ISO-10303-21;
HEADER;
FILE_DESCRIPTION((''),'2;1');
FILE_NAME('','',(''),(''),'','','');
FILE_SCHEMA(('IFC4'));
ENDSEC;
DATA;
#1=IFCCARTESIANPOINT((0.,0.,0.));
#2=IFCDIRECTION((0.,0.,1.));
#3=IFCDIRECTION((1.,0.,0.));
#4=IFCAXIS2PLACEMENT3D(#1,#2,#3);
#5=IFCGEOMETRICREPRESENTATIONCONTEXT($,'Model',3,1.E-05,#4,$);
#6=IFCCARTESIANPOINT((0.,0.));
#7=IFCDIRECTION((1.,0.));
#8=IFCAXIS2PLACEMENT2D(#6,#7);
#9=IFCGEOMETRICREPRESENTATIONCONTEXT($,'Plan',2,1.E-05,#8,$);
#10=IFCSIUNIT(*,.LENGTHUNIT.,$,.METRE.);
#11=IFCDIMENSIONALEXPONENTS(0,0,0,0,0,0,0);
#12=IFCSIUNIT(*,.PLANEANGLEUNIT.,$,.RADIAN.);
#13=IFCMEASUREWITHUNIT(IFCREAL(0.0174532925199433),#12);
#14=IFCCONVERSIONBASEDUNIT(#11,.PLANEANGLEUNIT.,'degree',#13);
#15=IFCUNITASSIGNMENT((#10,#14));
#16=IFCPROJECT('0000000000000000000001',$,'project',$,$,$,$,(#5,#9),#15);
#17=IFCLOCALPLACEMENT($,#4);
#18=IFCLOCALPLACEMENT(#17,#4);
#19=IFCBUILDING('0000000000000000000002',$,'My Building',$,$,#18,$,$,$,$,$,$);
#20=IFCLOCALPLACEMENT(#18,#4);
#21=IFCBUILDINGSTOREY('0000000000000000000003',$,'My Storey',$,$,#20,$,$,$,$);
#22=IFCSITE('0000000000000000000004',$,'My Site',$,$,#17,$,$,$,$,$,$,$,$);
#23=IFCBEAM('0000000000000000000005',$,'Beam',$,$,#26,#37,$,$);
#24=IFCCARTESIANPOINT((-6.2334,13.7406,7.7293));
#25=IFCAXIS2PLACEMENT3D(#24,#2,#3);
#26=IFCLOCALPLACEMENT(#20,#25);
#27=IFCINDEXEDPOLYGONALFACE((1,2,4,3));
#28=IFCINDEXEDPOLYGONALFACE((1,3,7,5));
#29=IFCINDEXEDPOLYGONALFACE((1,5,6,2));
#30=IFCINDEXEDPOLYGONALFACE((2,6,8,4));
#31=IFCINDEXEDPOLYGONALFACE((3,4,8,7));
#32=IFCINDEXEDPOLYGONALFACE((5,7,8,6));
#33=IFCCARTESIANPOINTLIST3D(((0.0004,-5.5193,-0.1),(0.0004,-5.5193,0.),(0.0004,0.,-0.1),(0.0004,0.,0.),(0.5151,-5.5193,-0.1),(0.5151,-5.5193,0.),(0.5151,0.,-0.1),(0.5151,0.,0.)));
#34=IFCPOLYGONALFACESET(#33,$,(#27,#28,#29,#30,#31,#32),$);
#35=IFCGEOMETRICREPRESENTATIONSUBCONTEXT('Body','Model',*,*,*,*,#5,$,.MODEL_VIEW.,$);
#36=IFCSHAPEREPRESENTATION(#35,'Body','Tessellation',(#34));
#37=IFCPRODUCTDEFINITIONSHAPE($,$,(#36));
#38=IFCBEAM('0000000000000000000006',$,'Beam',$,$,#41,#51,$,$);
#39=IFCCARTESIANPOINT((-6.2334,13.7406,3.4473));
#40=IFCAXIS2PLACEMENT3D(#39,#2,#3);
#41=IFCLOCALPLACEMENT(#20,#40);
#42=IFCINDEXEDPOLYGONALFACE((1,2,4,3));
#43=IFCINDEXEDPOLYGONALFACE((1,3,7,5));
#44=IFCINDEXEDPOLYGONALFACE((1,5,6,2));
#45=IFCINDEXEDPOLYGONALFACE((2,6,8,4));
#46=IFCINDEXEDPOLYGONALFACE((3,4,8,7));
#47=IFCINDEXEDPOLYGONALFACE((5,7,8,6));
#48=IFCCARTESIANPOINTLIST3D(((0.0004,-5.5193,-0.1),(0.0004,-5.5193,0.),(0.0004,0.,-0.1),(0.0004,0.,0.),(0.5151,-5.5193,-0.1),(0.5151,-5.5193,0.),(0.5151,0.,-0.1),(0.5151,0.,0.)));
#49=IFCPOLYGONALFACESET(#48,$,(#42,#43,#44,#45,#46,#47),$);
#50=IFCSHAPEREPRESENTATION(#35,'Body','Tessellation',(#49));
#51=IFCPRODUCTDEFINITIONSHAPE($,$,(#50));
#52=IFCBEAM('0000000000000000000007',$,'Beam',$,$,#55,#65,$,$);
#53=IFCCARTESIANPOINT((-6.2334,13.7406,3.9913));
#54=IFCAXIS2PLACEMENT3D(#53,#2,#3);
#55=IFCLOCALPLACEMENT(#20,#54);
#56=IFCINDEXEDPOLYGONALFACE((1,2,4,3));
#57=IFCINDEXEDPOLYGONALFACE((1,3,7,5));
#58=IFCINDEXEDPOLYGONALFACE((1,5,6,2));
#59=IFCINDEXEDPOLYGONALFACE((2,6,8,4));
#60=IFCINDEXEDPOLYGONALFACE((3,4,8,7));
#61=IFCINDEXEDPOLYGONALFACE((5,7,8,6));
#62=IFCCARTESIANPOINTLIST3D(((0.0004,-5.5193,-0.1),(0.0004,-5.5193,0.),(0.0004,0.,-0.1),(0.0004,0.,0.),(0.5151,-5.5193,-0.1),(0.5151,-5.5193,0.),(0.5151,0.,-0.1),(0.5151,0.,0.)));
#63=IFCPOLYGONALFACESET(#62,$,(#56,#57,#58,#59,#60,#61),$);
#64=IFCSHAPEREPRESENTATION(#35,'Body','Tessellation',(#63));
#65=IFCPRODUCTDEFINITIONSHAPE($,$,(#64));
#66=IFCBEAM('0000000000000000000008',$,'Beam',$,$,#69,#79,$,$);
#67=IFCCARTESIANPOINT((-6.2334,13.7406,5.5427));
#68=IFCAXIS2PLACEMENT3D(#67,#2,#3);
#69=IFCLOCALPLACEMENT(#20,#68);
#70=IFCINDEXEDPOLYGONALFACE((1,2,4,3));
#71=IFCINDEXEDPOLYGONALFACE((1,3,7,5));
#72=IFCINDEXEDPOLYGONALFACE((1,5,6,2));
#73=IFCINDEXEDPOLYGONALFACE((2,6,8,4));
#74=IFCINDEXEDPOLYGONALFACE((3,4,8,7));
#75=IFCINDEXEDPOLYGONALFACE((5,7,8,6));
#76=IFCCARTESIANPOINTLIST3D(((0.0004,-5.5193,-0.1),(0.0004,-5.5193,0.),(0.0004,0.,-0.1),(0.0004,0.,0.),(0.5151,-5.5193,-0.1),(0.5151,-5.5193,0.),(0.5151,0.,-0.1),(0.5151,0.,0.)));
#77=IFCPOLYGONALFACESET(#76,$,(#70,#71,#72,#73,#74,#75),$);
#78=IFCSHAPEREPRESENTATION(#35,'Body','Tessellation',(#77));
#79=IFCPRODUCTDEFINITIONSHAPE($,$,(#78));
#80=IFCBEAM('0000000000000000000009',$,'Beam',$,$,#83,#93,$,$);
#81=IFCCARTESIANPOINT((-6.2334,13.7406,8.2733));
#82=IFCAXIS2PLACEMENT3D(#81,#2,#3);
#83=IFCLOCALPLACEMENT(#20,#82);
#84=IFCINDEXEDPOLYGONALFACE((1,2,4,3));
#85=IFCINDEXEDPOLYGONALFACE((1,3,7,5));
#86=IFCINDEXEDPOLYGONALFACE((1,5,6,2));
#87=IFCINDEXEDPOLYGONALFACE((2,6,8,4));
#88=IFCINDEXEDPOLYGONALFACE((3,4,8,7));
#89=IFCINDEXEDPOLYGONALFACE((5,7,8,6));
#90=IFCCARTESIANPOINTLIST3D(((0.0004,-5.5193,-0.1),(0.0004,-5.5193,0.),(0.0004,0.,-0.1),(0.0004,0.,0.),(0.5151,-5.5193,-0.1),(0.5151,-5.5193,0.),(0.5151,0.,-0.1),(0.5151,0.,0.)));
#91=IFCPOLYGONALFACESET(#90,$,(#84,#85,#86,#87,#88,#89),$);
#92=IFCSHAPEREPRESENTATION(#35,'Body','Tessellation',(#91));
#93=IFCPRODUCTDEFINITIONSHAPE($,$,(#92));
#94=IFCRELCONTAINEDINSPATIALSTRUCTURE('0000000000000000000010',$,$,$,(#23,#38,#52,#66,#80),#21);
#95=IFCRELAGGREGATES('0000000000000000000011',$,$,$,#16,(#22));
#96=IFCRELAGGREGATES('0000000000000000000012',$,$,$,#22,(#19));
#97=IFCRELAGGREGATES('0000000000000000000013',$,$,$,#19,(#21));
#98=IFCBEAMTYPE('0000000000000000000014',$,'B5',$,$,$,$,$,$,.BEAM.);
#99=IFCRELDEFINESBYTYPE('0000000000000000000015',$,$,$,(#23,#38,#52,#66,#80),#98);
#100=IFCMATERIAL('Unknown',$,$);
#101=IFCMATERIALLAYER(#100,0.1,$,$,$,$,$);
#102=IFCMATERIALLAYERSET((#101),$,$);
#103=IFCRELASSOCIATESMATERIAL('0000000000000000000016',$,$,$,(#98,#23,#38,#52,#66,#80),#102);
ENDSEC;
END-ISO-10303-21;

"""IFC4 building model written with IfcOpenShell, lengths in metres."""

from ifc_helpers import new_model, entity, si_unit, converted_unit, frame, origin_with_axes, origin_2d_with_axis, place, context, subcontext, project, spatial, indexed_curve, outline, extrude, material, layer, layer_set, layer_usage, type_object, element, save


model = new_model("IFC4")

# Units and contexts
model_context = context("Model", 3, precision=1e-05, world=origin_with_axes())
plan_context = context("Plan", 2, precision=1e-05, world=origin_2d_with_axis())
body_context = subcontext(model_context, "Body", "Model", "MODEL_VIEW")
ifc_project = project(units=[si_unit("LENGTHUNIT", "METRE"), converted_unit("PLANEANGLEUNIT", "degree", entity("IfcReal", 0.0174532925199433), si_unit("PLANEANGLEUNIT", "RADIAN"), dimensions=[0, 0, 0, 0, 0, 0, 0])], contexts=[model_context, plan_context])

# Site, building, storey
site_placement = place(None, origin_with_axes())
site = spatial("IfcSite", under=ifc_project, at=site_placement, Name="My Site")
building_placement = place(site_placement, origin_with_axes())
building = spatial("IfcBuilding", under=site, at=building_placement, Name="My Building")
storey_placement = place(building_placement, origin_with_axes())
storey = spatial("IfcBuildingStorey", under=building, at=storey_placement, Name="My Storey")

# Shared definitions
ifc_material = material(Name="Unknown")

# Beams
ifc_layer_1 = layer(ifc_material, 0.1)
ifc_layer_set_1 = layer_set([ifc_layer_1])
beam_type_1 = type_object("IfcBeamType", Name="B5", PredefinedType="BEAM", material=ifc_layer_set_1)
ifc_layer_usage_1 = layer_usage(ifc_layer_set_1, "AXIS3", "POSITIVE", -0.1)
beam_1_placement = place(storey_placement, frame((-6.2334, 13.7406, 7.7293), z_axis=(0.0, 0.0, 1.0), x_axis=(1.0, 0.0, 0.0)))
element("IfcBeam", 1, at=beam_1_placement, inside=storey, type_object=beam_type_1, material=ifc_layer_usage_1, Name="Beam", context=body_context, shape_type="SweptSolid", body=[
    extrude(outline(indexed_curve([(0.0, 0.0), (0.5151, 0.0), (0.5151, -5.5193), (0.0004, -5.5193), (0.0004, 0.0), (0.0, 0.0)])), frame((0.0, 0.0, -0.1), z_axis=(0.0, 0.0, 1.0), x_axis=(1.0, 0.0, 0.0)), (0.0, 0.0, 1.0), 0.1),
])
ifc_layer_usage_2 = layer_usage(ifc_layer_set_1, "AXIS3", "POSITIVE", -0.1)
beam_2_placement = place(storey_placement, frame((-6.2334, 13.7406, 3.4473), z_axis=(0.0, 0.0, 1.0), x_axis=(1.0, 0.0, 0.0)))
element("IfcBeam", 2, at=beam_2_placement, inside=storey, type_object=beam_type_1, material=ifc_layer_usage_2, Name="Beam", context=body_context, shape_type="SweptSolid", body=[
    extrude(outline(indexed_curve([(0.0, 0.0), (0.5151, 0.0), (0.5151, -5.5193), (0.0004, -5.5193), (0.0004, 0.0), (0.0, 0.0)])), frame((0.0, 0.0, -0.1), z_axis=(0.0, 0.0, 1.0), x_axis=(1.0, 0.0, 0.0)), (0.0, 0.0, 1.0), 0.1),
])
ifc_layer_usage_3 = layer_usage(ifc_layer_set_1, "AXIS3", "POSITIVE", -0.1)
beam_3_placement = place(storey_placement, frame((-6.2334, 13.7406, 3.9913), z_axis=(0.0, 0.0, 1.0), x_axis=(1.0, 0.0, 0.0)))
element("IfcBeam", 3, at=beam_3_placement, inside=storey, type_object=beam_type_1, material=ifc_layer_usage_3, Name="Beam", context=body_context, shape_type="SweptSolid", body=[
    extrude(outline(indexed_curve([(0.0, 0.0), (0.5151, 0.0), (0.5151, -5.5193), (0.0004, -5.5193), (0.0004, 0.0), (0.0, 0.0)])), frame((0.0, 0.0, -0.1), z_axis=(0.0, 0.0, 1.0), x_axis=(1.0, 0.0, 0.0)), (0.0, 0.0, 1.0), 0.1),
])
ifc_layer_usage_4 = layer_usage(ifc_layer_set_1, "AXIS3", "POSITIVE", -0.1)
beam_4_placement = place(storey_placement, frame((-6.2334, 13.7406, 5.5427), z_axis=(0.0, 0.0, 1.0), x_axis=(1.0, 0.0, 0.0)))
element("IfcBeam", 4, at=beam_4_placement, inside=storey, type_object=beam_type_1, material=ifc_layer_usage_4, Name="Beam", context=body_context, shape_type="SweptSolid", body=[
    extrude(outline(indexed_curve([(0.0, 0.0), (0.5151, 0.0), (0.5151, -5.5193), (0.0004, -5.5193), (0.0004, 0.0), (0.0, 0.0)])), frame((0.0, 0.0, -0.1), z_axis=(0.0, 0.0, 1.0), x_axis=(1.0, 0.0, 0.0)), (0.0, 0.0, 1.0), 0.1),
])
ifc_layer_usage_5 = layer_usage(ifc_layer_set_1, "AXIS3", "POSITIVE", -0.1)
beam_5_placement = place(storey_placement, frame((-6.2334, 13.7406, 8.2733), z_axis=(0.0, 0.0, 1.0), x_axis=(1.0, 0.0, 0.0)))
element("IfcBeam", 5, at=beam_5_placement, inside=storey, type_object=beam_type_1, material=ifc_layer_usage_5, Name="Beam", context=body_context, shape_type="SweptSolid", body=[
    extrude(outline(indexed_curve([(0.0, 0.0), (0.5151, 0.0), (0.5151, -5.5193), (0.0004, -5.5193), (0.0004, 0.0), (0.0, 0.0)])), frame((0.0, 0.0, -0.1), z_axis=(0.0, 0.0, 1.0), x_axis=(1.0, 0.0, 0.0)), (0.0, 0.0, 1.0), 0.1),
])

save(model, "model.ifc")
